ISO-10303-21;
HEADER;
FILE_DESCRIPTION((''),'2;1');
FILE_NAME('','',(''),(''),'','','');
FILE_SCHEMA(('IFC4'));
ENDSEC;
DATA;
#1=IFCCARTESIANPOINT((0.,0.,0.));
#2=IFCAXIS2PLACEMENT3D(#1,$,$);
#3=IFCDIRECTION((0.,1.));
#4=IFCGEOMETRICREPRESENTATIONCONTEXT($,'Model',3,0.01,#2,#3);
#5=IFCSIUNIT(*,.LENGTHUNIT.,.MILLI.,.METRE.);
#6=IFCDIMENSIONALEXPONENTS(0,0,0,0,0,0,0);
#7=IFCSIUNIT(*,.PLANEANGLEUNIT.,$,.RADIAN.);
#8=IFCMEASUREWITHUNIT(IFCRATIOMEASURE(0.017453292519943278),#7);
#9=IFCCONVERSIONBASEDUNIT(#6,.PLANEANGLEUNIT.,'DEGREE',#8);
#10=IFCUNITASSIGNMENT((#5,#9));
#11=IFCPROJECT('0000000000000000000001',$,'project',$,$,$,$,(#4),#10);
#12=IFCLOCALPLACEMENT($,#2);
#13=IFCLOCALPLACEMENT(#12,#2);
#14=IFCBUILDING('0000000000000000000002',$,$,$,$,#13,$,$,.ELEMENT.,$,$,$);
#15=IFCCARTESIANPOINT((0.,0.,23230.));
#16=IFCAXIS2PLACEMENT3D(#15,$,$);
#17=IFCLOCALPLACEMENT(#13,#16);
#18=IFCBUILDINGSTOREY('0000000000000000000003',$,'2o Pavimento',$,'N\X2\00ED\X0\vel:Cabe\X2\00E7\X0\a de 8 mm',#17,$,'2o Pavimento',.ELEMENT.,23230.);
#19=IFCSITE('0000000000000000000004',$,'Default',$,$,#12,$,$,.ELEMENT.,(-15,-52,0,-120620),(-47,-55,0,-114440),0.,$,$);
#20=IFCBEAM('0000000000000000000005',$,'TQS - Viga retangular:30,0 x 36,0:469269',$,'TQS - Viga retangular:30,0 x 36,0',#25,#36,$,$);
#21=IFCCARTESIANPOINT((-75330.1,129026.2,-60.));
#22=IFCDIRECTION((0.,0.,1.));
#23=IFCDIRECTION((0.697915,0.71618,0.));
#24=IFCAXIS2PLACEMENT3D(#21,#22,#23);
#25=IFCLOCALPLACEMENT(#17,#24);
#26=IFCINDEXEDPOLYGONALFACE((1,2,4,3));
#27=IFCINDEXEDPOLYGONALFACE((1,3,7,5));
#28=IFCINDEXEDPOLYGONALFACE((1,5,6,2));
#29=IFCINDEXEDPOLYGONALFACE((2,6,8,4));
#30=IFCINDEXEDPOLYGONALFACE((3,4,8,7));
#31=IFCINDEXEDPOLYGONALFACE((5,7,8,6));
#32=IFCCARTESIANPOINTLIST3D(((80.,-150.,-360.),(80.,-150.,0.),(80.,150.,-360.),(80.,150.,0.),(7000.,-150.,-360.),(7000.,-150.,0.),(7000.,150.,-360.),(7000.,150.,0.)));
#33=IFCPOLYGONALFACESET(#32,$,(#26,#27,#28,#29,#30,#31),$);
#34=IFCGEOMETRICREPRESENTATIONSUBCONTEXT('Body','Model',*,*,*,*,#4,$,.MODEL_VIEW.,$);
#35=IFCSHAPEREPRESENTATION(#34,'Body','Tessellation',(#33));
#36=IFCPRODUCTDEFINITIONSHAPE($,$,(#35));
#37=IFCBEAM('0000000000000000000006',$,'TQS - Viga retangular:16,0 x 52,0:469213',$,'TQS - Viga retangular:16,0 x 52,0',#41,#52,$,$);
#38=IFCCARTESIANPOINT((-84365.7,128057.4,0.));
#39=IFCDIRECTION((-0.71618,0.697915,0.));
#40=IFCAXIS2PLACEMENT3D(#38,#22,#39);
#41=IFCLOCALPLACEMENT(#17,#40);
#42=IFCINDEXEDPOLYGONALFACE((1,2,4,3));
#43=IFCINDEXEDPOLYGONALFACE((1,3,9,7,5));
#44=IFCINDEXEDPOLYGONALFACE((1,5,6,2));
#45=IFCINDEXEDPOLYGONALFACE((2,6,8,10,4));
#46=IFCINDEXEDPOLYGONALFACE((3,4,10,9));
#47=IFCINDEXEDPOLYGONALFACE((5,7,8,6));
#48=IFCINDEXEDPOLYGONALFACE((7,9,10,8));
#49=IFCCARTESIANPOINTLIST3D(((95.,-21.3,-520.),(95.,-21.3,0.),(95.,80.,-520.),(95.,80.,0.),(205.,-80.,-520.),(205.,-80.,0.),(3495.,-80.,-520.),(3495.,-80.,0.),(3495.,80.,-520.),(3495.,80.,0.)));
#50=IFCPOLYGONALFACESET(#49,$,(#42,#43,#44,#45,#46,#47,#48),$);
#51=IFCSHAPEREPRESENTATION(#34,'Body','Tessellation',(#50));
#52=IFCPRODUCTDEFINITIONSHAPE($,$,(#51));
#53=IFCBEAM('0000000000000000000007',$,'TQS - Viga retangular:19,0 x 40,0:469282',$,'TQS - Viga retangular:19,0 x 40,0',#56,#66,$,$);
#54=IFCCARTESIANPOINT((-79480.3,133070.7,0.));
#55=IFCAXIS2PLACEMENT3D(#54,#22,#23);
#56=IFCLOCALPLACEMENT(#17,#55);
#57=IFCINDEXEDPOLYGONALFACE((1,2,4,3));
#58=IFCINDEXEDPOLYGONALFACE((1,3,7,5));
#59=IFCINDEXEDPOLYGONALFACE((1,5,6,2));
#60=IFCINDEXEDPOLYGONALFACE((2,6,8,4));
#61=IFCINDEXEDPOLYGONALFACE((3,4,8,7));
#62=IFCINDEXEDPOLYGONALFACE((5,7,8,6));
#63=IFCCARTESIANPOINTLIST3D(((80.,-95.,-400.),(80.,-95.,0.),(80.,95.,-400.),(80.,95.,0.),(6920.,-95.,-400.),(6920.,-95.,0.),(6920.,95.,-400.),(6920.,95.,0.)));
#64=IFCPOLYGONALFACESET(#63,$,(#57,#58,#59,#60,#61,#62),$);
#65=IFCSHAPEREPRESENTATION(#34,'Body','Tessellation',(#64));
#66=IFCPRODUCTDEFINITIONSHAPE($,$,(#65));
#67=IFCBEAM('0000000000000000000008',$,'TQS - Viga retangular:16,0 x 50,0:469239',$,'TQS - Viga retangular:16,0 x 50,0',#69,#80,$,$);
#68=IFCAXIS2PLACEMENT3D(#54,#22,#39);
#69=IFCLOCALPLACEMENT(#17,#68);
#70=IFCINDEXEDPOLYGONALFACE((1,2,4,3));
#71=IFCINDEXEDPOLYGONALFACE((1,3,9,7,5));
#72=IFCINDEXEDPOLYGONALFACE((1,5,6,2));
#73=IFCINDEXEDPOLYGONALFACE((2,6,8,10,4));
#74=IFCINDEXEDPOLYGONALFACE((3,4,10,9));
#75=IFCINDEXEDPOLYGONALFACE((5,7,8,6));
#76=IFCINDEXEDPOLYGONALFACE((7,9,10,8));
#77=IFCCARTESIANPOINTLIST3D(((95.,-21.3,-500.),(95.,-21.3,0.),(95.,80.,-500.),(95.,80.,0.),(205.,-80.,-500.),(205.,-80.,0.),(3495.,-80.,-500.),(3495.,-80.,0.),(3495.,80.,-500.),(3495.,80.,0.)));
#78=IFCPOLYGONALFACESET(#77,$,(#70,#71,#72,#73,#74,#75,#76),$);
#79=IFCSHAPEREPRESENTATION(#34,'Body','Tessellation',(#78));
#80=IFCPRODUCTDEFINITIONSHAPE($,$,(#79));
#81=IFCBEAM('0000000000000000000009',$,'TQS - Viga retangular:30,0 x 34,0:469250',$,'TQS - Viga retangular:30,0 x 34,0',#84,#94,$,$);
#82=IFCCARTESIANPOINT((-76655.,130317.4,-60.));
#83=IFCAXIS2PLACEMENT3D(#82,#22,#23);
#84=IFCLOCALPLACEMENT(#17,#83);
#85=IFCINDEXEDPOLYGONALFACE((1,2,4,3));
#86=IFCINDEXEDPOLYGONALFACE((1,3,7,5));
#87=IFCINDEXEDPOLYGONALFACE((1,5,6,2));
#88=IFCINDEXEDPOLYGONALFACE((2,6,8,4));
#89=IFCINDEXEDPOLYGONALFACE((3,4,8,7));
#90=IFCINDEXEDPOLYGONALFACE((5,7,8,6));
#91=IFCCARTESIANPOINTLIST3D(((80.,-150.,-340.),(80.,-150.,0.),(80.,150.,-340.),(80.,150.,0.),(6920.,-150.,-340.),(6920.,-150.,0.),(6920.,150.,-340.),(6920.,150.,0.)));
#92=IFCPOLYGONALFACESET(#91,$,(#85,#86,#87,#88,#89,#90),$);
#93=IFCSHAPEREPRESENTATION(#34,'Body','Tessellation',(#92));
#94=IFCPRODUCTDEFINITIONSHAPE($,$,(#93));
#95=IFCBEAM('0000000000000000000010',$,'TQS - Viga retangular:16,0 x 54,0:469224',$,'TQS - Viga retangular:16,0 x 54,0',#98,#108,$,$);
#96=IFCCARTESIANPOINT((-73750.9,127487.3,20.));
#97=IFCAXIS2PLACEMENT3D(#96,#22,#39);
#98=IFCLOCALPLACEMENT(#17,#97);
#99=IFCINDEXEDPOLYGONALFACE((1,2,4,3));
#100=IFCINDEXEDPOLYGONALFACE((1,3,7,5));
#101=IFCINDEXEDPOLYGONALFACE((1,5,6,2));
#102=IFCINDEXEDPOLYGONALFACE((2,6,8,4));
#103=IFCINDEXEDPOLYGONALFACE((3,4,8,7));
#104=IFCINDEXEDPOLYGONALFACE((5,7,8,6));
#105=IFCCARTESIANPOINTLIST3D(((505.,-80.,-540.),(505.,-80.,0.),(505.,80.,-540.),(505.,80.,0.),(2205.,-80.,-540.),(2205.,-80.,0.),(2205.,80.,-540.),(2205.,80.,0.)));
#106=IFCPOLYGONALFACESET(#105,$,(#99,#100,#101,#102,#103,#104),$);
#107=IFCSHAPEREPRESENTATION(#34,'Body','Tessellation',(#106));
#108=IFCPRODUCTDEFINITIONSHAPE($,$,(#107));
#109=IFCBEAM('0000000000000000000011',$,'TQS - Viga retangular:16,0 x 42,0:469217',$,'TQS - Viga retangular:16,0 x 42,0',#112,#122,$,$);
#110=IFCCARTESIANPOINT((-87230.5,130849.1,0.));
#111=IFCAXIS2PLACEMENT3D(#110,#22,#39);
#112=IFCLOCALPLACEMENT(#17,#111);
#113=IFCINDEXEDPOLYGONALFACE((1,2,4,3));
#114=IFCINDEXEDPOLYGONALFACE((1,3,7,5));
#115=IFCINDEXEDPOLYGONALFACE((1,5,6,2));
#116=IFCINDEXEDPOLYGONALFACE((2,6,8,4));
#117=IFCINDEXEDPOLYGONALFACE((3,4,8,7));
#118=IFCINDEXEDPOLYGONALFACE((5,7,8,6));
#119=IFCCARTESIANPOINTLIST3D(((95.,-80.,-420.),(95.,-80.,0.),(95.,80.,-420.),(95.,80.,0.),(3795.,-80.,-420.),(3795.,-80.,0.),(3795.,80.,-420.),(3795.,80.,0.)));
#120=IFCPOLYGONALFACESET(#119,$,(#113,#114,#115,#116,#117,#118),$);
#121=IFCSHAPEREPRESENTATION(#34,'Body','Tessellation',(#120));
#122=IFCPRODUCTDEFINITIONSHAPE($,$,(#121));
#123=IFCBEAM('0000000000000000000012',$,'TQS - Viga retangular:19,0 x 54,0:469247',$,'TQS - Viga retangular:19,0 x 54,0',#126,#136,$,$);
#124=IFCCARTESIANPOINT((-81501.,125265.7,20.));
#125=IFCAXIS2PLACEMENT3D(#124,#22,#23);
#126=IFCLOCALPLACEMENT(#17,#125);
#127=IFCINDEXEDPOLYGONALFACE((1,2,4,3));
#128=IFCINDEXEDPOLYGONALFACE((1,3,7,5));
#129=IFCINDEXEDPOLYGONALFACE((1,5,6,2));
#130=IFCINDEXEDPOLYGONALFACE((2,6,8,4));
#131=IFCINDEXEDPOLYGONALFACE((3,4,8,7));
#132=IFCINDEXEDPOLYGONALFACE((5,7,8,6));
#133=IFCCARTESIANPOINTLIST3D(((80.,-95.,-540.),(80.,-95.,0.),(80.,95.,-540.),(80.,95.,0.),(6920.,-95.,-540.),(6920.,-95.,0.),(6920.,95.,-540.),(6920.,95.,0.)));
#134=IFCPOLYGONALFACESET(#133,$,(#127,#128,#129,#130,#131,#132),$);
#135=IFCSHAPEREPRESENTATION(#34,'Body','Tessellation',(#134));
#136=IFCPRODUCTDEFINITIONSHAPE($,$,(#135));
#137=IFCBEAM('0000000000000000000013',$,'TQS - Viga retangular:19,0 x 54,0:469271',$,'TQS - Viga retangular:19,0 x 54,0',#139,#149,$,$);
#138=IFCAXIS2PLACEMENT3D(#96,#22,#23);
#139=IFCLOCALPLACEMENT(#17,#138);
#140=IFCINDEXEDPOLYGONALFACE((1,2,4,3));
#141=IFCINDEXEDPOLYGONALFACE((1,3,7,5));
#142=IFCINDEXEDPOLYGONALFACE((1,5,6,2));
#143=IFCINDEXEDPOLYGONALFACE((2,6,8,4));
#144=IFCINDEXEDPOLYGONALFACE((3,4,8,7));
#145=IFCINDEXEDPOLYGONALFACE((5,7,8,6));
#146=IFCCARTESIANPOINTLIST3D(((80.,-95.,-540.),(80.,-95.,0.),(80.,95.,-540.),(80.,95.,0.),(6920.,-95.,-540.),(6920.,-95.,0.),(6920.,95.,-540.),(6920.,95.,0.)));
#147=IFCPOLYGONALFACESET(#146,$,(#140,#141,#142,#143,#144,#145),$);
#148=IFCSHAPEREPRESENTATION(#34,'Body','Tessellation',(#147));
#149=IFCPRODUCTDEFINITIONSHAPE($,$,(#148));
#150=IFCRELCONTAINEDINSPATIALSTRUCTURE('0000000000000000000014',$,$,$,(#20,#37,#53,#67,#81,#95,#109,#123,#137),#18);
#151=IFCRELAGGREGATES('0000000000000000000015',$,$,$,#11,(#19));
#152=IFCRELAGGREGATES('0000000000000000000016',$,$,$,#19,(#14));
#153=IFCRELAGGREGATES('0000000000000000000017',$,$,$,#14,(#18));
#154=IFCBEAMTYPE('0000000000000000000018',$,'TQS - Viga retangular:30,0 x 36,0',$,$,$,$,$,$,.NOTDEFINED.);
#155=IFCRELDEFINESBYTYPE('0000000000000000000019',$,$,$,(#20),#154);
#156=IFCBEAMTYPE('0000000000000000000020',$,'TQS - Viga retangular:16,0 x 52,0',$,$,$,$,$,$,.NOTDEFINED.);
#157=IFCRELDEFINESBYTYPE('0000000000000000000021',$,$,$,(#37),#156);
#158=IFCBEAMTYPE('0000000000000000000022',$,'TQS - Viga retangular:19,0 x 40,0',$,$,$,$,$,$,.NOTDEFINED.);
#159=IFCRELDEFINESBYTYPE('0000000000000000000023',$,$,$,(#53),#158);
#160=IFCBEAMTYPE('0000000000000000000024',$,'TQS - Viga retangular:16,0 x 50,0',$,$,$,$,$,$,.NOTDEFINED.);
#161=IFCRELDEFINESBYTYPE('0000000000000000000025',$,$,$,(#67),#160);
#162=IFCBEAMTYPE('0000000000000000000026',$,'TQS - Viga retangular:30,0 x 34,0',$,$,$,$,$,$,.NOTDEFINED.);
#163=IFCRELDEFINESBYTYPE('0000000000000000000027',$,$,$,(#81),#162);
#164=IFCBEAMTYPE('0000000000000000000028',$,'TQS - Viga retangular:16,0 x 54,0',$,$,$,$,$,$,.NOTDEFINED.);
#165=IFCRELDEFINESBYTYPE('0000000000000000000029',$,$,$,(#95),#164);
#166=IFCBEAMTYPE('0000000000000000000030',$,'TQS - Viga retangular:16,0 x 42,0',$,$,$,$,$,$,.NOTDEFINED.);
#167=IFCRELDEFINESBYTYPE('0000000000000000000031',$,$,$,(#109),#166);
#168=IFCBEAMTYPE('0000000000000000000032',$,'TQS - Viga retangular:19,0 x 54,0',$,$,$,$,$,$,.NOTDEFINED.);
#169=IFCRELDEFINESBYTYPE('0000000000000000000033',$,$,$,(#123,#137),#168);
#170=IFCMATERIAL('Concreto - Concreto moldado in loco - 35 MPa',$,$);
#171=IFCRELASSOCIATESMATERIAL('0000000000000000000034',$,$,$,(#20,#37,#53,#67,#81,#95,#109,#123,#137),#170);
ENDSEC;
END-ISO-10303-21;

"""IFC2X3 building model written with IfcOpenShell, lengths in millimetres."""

from ifc_helpers import new_model, entity, si_unit, converted_unit, direction, frame, frame_2d, origin, place, context, subcontext, project, spatial, rectangle, extrude, clip, halfspace, material, type_object, element, save


model = new_model("IFC2X3")

# Units and contexts
model_context = context("Model", 3, precision=0.01, world=origin(), true_north=direction((0.0, 1.0)))
body_context = subcontext(model_context, "Body", "Model", "MODEL_VIEW")
ifc_project = project(units=[si_unit("LENGTHUNIT", "METRE", prefix="MILLI"), converted_unit("PLANEANGLEUNIT", "DEGREE", entity("IfcRatioMeasure", 0.017453292519943278), si_unit("PLANEANGLEUNIT", "RADIAN"), dimensions=[0, 0, 0, 0, 0, 0, 0])], contexts=[model_context])

# Site, building, storey
site_placement = place(None, origin())
site = spatial("IfcSite", under=ifc_project, at=site_placement, Name="Default", CompositionType="ELEMENT", RefLatitude=(-15, -52, 0, -120620), RefLongitude=(-47, -55, 0, -114440), RefElevation=0.0)
building_placement = place(site_placement, origin())
building = spatial("IfcBuilding", under=site, at=building_placement, CompositionType="ELEMENT")
storey_placement = place(building_placement, frame((0.0, 0.0, 23230.0)))
storey = spatial("IfcBuildingStorey", under=building, at=storey_placement, Name="2o Pavimento", ObjectType="Nível:Cabeça de 8 mm", LongName="2o Pavimento", CompositionType="ELEMENT", Elevation=23230.0)

# Beams
ifc_material = material(Name="Concreto - Concreto moldado in loco - 35 MPa")
beam_type_1 = type_object("IfcBeamType", Name="TQS - Viga retangular:30,0 x 36,0", PredefinedType="NOTDEFINED")
beam_1_placement = place(storey_placement, frame((-75330.1, 129026.2, -60.0), z_axis=(0.0, 0.0, 1.0), x_axis=(0.697915, 0.71618, 0.0)))
element("IfcBeam", 1, at=beam_1_placement, inside=storey, type_object=beam_type_1, material=ifc_material, Name="TQS - Viga retangular:30,0 x 36,0:469269", ObjectType="TQS - Viga retangular:30,0 x 36,0", context=body_context, shape_type="SweptSolid", body=[
    extrude(rectangle(XDim=360.0, YDim=300.0, at=frame_2d((0.0, 0.0), x_axis=(1.0, 0.0))), frame((80.0, 0.0, -180.0), z_axis=(1.0, 0.0, 0.0), x_axis=(0.0, 0.0, -1.0)), (0.0, 0.0, 1.0), 6920.0),
])
beam_type_2 = type_object("IfcBeamType", Name="TQS - Viga retangular:16,0 x 52,0", PredefinedType="NOTDEFINED")
beam_2_placement = place(storey_placement, frame((-84365.7, 128057.4, 0.0), z_axis=(0.0, 0.0, 1.0), x_axis=(-0.71618, 0.697915, 0.0)))
element("IfcBeam", 2, at=beam_2_placement, inside=storey, type_object=beam_type_2, material=ifc_material, Name="TQS - Viga retangular:16,0 x 52,0:469213", ObjectType="TQS - Viga retangular:16,0 x 52,0", context=body_context, shape_type="SweptSolid", body=[
    clip(extrude(rectangle(XDim=520.0, YDim=160.0, at=frame_2d((0.0, 0.0), x_axis=(1.0, 0.0))), frame((95.0, 0.0, -260.0), z_axis=(1.0, 0.0, 0.0), x_axis=(0.0, 0.0, -1.0)), (0.0, 0.0, 1.0), 3400.0), halfspace(frame((205.0, -80.0, 0.0), z_axis=(-0.470588, -0.882353, 0.0), x_axis=(-0.882353, 0.470588, 0.0)), False)),
])
beam_type_3 = type_object("IfcBeamType", Name="TQS - Viga retangular:19,0 x 40,0", PredefinedType="NOTDEFINED")
beam_3_placement = place(storey_placement, frame((-79480.3, 133070.7, 0.0), z_axis=(0.0, 0.0, 1.0), x_axis=(0.697915, 0.71618, 0.0)))
element("IfcBeam", 3, at=beam_3_placement, inside=storey, type_object=beam_type_3, material=ifc_material, Name="TQS - Viga retangular:19,0 x 40,0:469282", ObjectType="TQS - Viga retangular:19,0 x 40,0", context=body_context, shape_type="SweptSolid", body=[
    extrude(rectangle(XDim=400.0, YDim=190.0, at=frame_2d((0.0, 0.0), x_axis=(1.0, 0.0))), frame((80.0, 0.0, -200.0), z_axis=(1.0, 0.0, 0.0), x_axis=(0.0, 0.0, -1.0)), (0.0, 0.0, 1.0), 6840.0),
])
beam_type_4 = type_object("IfcBeamType", Name="TQS - Viga retangular:16,0 x 50,0", PredefinedType="NOTDEFINED")
beam_4_placement = place(storey_placement, frame((-79480.3, 133070.7, 0.0), z_axis=(0.0, 0.0, 1.0), x_axis=(-0.71618, 0.697915, 0.0)))
element("IfcBeam", 4, at=beam_4_placement, inside=storey, type_object=beam_type_4, material=ifc_material, Name="TQS - Viga retangular:16,0 x 50,0:469239", ObjectType="TQS - Viga retangular:16,0 x 50,0", context=body_context, shape_type="SweptSolid", body=[
    clip(extrude(rectangle(XDim=500.0, YDim=160.0, at=frame_2d((0.0, 0.0), x_axis=(1.0, 0.0))), frame((95.0, 0.0, -250.0), z_axis=(1.0, 0.0, 0.0), x_axis=(0.0, 0.0, -1.0)), (0.0, 0.0, 1.0), 3400.0), halfspace(frame((-95.0, 80.0, 0.0), z_axis=(-0.470588, -0.882353, 0.0), x_axis=(-0.882353, 0.470588, 0.0)), False)),
])
beam_type_5 = type_object("IfcBeamType", Name="TQS - Viga retangular:30,0 x 34,0", PredefinedType="NOTDEFINED")
beam_5_placement = place(storey_placement, frame((-76655.0, 130317.4, -60.0), z_axis=(0.0, 0.0, 1.0), x_axis=(0.697915, 0.71618, 0.0)))
element("IfcBeam", 5, at=beam_5_placement, inside=storey, type_object=beam_type_5, material=ifc_material, Name="TQS - Viga retangular:30,0 x 34,0:469250", ObjectType="TQS - Viga retangular:30,0 x 34,0", context=body_context, shape_type="SweptSolid", body=[
    extrude(rectangle(XDim=340.0, YDim=300.0, at=frame_2d((0.0, 0.0), x_axis=(1.0, 0.0))), frame((80.0, 0.0, -170.0), z_axis=(1.0, 0.0, 0.0), x_axis=(0.0, 0.0, -1.0)), (0.0, 0.0, 1.0), 6840.0),
])
beam_type_6 = type_object("IfcBeamType", Name="TQS - Viga retangular:16,0 x 54,0", PredefinedType="NOTDEFINED")
beam_6_placement = place(storey_placement, frame((-73750.9, 127487.3, 20.0), z_axis=(0.0, 0.0, 1.0), x_axis=(-0.71618, 0.697915, 0.0)))
element("IfcBeam", 6, at=beam_6_placement, inside=storey, type_object=beam_type_6, material=ifc_material, Name="TQS - Viga retangular:16,0 x 54,0:469224", ObjectType="TQS - Viga retangular:16,0 x 54,0", context=body_context, shape_type="SweptSolid", body=[
    extrude(rectangle(XDim=540.0, YDim=160.0, at=frame_2d((0.0, 0.0), x_axis=(1.0, 0.0))), frame((505.0, 0.0, -270.0), z_axis=(1.0, 0.0, 0.0), x_axis=(0.0, 0.0, -1.0)), (0.0, 0.0, 1.0), 1700.0),
])
beam_type_7 = type_object("IfcBeamType", Name="TQS - Viga retangular:16,0 x 42,0", PredefinedType="NOTDEFINED")
beam_7_placement = place(storey_placement, frame((-87230.5, 130849.1, 0.0), z_axis=(0.0, 0.0, 1.0), x_axis=(-0.71618, 0.697915, 0.0)))
element("IfcBeam", 7, at=beam_7_placement, inside=storey, type_object=beam_type_7, material=ifc_material, Name="TQS - Viga retangular:16,0 x 42,0:469217", ObjectType="TQS - Viga retangular:16,0 x 42,0", context=body_context, shape_type="SweptSolid", body=[
    extrude(rectangle(XDim=420.0, YDim=160.0, at=frame_2d((0.0, 0.0), x_axis=(1.0, 0.0))), frame((95.0, 0.0, -210.0), z_axis=(1.0, 0.0, 0.0), x_axis=(0.0, 0.0, -1.0)), (0.0, 0.0, 1.0), 3700.0),
])
beam_type_8 = type_object("IfcBeamType", Name="TQS - Viga retangular:19,0 x 54,0", PredefinedType="NOTDEFINED")
beam_8_placement = place(storey_placement, frame((-81501.0, 125265.7, 20.0), z_axis=(0.0, 0.0, 1.0), x_axis=(0.697915, 0.71618, 0.0)))
element("IfcBeam", 8, at=beam_8_placement, inside=storey, type_object=beam_type_8, material=ifc_material, Name="TQS - Viga retangular:19,0 x 54,0:469247", ObjectType="TQS - Viga retangular:19,0 x 54,0", context=body_context, shape_type="SweptSolid", body=[
    extrude(rectangle(XDim=540.0, YDim=190.0, at=frame_2d((0.0, 0.0), x_axis=(1.0, 0.0))), frame((80.0, 0.0, -270.0), z_axis=(1.0, 0.0, 0.0), x_axis=(0.0, 0.0, -1.0)), (0.0, 0.0, 1.0), 6840.0),
])
beam_9_placement = place(storey_placement, frame((-73750.9, 127487.3, 20.0), z_axis=(0.0, 0.0, 1.0), x_axis=(0.697915, 0.71618, 0.0)))
element("IfcBeam", 9, at=beam_9_placement, inside=storey, type_object=beam_type_8, material=ifc_material, Name="TQS - Viga retangular:19,0 x 54,0:469271", ObjectType="TQS - Viga retangular:19,0 x 54,0", context=body_context, shape_type="SweptSolid", body=[
    extrude(rectangle(XDim=540.0, YDim=190.0, at=frame_2d((0.0, 0.0), x_axis=(1.0, 0.0))), frame((80.0, 0.0, -270.0), z_axis=(1.0, 0.0, 0.0), x_axis=(0.0, 0.0, -1.0)), (0.0, 0.0, 1.0), 6840.0),
])

save(model, "model.ifc")
